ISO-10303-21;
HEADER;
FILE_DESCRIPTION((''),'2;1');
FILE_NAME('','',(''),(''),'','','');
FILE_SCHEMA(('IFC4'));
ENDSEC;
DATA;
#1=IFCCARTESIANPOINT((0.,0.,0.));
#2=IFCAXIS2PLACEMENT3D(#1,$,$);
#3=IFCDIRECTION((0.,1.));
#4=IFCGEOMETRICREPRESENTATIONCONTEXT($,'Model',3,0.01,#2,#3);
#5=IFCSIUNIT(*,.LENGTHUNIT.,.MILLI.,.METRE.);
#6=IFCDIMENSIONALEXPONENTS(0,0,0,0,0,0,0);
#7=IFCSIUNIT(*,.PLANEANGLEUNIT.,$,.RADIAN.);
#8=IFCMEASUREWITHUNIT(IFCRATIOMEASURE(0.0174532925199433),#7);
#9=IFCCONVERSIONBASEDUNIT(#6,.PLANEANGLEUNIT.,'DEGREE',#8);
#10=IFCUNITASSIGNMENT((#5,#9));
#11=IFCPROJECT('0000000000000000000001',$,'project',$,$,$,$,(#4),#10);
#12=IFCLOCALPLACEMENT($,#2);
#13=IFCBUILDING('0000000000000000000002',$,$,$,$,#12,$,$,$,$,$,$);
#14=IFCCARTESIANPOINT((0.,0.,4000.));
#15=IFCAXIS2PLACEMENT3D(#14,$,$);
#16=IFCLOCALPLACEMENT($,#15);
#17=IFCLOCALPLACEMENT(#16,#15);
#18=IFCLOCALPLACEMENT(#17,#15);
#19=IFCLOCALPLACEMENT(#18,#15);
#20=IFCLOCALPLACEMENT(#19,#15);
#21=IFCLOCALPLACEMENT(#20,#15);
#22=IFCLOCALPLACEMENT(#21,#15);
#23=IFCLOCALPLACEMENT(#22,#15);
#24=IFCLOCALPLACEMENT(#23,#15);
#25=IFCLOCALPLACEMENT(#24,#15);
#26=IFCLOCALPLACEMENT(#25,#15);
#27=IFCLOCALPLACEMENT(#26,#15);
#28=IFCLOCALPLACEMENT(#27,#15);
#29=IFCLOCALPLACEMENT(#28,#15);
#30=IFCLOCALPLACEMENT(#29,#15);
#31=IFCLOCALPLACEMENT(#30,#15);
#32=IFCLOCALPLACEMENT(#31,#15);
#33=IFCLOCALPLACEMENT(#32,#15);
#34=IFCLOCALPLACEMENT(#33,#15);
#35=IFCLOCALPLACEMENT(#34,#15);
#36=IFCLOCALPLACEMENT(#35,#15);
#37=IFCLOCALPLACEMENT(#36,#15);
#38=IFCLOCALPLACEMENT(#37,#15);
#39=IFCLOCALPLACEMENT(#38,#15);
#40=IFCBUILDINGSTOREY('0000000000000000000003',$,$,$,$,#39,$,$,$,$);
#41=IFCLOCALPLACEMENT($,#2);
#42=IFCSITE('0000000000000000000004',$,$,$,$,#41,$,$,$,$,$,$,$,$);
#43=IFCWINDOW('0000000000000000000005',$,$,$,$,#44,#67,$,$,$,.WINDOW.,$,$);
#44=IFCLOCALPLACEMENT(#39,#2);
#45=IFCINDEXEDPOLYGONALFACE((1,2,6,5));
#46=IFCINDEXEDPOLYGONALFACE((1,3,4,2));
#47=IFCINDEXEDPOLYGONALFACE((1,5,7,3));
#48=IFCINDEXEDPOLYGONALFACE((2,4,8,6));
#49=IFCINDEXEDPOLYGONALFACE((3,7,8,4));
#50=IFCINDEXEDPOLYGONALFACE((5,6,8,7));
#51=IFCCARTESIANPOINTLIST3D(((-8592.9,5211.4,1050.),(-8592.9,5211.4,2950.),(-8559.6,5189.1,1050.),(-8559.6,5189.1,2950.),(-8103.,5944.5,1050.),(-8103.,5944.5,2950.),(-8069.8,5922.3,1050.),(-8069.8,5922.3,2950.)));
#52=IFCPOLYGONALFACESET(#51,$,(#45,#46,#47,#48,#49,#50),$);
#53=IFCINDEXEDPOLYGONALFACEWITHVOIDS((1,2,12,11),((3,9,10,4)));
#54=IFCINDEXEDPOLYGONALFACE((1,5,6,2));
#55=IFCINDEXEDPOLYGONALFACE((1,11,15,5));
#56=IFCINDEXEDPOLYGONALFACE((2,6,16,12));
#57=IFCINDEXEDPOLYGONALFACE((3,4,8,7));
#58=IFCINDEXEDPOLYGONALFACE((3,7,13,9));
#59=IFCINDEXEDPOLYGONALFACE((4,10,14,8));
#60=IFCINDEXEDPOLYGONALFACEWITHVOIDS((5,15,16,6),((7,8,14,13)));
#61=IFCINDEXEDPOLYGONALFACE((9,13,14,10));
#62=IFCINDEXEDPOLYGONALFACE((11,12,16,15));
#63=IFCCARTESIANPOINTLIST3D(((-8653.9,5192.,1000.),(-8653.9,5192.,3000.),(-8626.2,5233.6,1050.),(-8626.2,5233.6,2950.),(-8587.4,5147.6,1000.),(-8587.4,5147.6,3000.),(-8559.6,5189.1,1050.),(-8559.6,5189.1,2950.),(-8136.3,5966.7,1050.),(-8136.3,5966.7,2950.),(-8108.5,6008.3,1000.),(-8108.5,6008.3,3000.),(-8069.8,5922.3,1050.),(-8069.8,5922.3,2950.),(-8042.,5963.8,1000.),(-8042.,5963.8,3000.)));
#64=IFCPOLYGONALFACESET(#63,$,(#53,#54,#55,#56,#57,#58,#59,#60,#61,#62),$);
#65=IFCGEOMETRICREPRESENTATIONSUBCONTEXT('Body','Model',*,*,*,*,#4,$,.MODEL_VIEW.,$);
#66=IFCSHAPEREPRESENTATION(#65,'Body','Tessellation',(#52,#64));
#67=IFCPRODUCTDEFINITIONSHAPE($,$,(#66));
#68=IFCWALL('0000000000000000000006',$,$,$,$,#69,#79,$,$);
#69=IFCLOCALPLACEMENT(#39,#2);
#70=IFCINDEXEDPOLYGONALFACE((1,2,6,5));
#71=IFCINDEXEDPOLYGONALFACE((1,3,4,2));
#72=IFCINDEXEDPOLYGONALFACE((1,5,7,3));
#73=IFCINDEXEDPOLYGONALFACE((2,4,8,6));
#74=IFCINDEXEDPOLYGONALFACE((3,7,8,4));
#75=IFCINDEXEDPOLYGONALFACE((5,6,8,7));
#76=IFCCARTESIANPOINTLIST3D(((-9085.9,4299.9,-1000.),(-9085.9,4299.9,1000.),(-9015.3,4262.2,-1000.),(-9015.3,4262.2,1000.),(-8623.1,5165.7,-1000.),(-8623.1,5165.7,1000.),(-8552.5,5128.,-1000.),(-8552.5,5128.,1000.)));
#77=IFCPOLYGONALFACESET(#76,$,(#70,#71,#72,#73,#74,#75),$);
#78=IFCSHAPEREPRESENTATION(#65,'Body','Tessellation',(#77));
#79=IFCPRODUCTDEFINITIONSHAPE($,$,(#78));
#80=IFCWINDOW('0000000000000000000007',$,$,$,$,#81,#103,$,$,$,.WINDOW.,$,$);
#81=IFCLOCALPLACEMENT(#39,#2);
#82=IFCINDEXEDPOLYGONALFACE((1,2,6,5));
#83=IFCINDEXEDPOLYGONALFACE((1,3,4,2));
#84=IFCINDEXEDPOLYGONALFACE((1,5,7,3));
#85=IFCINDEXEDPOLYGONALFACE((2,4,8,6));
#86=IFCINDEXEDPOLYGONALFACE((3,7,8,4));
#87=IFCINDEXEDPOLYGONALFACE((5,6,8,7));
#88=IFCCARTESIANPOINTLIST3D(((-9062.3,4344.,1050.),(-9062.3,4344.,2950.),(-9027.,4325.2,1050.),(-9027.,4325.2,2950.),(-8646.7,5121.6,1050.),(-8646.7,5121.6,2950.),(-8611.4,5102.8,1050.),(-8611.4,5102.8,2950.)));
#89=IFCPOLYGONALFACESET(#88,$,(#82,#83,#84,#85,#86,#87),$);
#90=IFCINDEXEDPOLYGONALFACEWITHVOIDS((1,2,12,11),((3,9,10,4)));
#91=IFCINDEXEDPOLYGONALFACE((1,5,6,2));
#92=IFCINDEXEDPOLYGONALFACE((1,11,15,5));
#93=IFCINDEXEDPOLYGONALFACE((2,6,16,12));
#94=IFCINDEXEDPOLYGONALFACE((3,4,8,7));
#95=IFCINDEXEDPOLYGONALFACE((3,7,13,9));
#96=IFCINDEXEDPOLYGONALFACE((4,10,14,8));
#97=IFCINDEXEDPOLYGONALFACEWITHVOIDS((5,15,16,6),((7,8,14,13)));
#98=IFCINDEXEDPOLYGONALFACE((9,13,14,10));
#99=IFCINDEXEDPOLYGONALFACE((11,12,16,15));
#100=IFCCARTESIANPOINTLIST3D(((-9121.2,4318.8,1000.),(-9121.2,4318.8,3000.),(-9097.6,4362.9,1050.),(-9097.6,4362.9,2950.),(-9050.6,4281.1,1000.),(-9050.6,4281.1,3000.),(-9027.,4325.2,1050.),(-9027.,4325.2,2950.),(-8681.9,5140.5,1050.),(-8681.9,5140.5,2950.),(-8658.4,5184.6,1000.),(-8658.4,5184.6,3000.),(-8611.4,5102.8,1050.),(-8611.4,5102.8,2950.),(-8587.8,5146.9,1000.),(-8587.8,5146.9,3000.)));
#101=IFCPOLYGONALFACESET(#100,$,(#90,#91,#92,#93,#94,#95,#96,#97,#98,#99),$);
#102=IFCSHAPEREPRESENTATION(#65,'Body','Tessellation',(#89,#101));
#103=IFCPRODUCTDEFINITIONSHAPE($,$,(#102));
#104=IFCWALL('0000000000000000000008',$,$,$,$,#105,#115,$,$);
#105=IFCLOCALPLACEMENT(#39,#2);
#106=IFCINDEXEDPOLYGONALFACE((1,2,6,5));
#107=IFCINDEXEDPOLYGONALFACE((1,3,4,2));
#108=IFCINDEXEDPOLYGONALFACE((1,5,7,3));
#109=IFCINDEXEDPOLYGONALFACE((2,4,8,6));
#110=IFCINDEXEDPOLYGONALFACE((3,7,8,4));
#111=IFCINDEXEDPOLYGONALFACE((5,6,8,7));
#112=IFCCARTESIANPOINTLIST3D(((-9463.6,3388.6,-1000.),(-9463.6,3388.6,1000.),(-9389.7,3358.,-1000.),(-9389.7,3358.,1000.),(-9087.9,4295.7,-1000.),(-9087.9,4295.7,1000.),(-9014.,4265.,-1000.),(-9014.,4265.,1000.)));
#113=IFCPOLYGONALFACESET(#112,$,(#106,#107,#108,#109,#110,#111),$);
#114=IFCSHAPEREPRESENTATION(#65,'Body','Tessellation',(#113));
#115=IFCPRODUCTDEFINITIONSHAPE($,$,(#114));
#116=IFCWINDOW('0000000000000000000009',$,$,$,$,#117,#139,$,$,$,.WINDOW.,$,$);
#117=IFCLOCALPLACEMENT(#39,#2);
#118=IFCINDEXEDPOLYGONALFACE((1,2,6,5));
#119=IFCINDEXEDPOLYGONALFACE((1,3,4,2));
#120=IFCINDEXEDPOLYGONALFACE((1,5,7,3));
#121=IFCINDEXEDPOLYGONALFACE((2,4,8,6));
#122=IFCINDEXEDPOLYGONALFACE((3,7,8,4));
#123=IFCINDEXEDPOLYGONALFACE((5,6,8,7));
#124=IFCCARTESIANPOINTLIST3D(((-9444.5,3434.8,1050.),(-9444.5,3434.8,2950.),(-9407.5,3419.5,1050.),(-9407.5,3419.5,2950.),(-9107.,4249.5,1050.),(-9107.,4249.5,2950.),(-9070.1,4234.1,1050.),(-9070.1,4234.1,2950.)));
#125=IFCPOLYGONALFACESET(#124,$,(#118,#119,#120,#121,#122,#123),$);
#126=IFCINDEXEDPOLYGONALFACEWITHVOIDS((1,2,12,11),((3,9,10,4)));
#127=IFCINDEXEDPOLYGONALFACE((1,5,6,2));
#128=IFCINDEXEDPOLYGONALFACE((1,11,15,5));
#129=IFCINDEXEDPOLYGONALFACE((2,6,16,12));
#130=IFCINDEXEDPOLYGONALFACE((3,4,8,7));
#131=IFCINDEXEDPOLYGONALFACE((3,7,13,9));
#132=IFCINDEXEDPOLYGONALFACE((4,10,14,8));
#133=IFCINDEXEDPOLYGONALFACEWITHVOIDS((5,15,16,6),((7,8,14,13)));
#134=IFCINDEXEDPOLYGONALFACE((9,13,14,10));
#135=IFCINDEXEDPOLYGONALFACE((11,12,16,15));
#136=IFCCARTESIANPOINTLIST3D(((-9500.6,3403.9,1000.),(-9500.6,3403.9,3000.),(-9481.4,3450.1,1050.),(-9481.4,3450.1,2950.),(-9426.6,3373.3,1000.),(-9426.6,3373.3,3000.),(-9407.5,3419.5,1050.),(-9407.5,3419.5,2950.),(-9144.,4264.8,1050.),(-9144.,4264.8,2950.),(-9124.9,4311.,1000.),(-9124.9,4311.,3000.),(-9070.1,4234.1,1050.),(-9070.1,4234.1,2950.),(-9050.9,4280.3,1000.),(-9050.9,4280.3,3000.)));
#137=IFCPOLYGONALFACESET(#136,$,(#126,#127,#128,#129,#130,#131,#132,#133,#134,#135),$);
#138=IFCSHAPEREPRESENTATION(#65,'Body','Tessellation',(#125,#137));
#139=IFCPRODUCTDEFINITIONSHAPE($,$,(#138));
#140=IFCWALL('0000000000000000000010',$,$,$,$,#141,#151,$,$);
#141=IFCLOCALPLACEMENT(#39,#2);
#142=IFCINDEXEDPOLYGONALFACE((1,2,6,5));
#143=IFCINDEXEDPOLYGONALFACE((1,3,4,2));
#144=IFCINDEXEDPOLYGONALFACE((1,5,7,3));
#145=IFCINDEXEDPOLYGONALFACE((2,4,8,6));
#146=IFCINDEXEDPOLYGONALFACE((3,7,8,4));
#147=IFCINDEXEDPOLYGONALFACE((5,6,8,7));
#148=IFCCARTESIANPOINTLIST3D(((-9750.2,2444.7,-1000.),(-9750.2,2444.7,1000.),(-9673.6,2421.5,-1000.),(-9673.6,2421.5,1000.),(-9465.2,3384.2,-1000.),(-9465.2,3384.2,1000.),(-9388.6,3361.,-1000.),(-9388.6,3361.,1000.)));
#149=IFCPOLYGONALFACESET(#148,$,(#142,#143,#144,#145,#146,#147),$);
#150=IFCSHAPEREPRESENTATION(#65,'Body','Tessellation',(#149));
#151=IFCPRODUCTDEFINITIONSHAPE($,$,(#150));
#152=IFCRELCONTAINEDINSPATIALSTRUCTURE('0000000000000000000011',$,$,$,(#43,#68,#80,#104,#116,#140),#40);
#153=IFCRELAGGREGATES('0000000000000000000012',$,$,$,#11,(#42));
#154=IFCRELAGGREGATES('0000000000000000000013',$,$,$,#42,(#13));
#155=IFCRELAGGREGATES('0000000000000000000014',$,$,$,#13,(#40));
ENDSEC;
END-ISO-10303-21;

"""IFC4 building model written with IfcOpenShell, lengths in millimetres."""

from ifc_helpers import new_model, entity, si_unit, converted_unit, direction, frame, origin, origin_2d, place, context, subcontext, project, spatial, rectangle, extrude, element, save


model = new_model("IFC4")

# Units and contexts
model_context = context("Model", 3, precision=0.01, world=origin(), true_north=direction((0.0, 1.0)))
body_context = subcontext(model_context, "Body", "Model", "MODEL_VIEW")
ifc_project = project(units=[si_unit("LENGTHUNIT", "METRE", prefix="MILLI"), converted_unit("PLANEANGLEUNIT", "DEGREE", entity("IfcRatioMeasure", 0.0174532925199433), si_unit("PLANEANGLEUNIT", "RADIAN"), dimensions=[0, 0, 0, 0, 0, 0, 0])], contexts=[model_context])

# Site, building, storey
site_placement = place(None, origin())
site = spatial("IfcSite", under=ifc_project, at=site_placement)
building_placement = place(None, origin())
building = spatial("IfcBuilding", under=site, at=building_placement)
placement_1 = place(None, frame((0.0, 0.0, 4000.0)))
placement_2 = place(placement_1, frame((0.0, 0.0, 4000.0)))
placement_3 = place(placement_2, frame((0.0, 0.0, 4000.0)))
placement_4 = place(placement_3, frame((0.0, 0.0, 4000.0)))
placement_5 = place(placement_4, frame((0.0, 0.0, 4000.0)))
placement_6 = place(placement_5, frame((0.0, 0.0, 4000.0)))
placement_7 = place(placement_6, frame((0.0, 0.0, 4000.0)))
placement_8 = place(placement_7, frame((0.0, 0.0, 4000.0)))
placement_9 = place(placement_8, frame((0.0, 0.0, 4000.0)))
placement_10 = place(placement_9, frame((0.0, 0.0, 4000.0)))
placement_11 = place(placement_10, frame((0.0, 0.0, 4000.0)))
placement_12 = place(placement_11, frame((0.0, 0.0, 4000.0)))
placement_13 = place(placement_12, frame((0.0, 0.0, 4000.0)))
placement_14 = place(placement_13, frame((0.0, 0.0, 4000.0)))
placement_15 = place(placement_14, frame((0.0, 0.0, 4000.0)))
placement_16 = place(placement_15, frame((0.0, 0.0, 4000.0)))
placement_17 = place(placement_16, frame((0.0, 0.0, 4000.0)))
placement_18 = place(placement_17, frame((0.0, 0.0, 4000.0)))
placement_19 = place(placement_18, frame((0.0, 0.0, 4000.0)))
placement_20 = place(placement_19, frame((0.0, 0.0, 4000.0)))
placement_21 = place(placement_20, frame((0.0, 0.0, 4000.0)))
placement_22 = place(placement_21, frame((0.0, 0.0, 4000.0)))
placement_23 = place(placement_22, frame((0.0, 0.0, 4000.0)))
storey_placement = place(placement_23, frame((0.0, 0.0, 4000.0)))
storey = spatial("IfcBuildingStorey", under=building, at=storey_placement)

# Shared definitions
cartesian_point_1 = entity("IfcCartesianPoint", [-440.9, -950.0])
shared_polyline = entity("IfcPolyline", [cartesian_point_1, entity("IfcCartesianPoint", [-440.9, 950.0]), entity("IfcCartesianPoint", [-440.9, 950.0]), entity("IfcCartesianPoint", [440.9, 950.0]), entity("IfcCartesianPoint", [440.9, 950.0]), entity("IfcCartesianPoint", [440.9, -950.0]), entity("IfcCartesianPoint", [440.9, -950.0]), entity("IfcCartesianPoint", [-440.9, -950.0]), cartesian_point_1])

# Window
window_1_placement = place(storey_placement, frame((-8314.7, 5555.7, 2000.0), z_axis=(0.0, 0.0, 1.0), x_axis=(-5555.701616, -8314.6966, 0.0)))
cartesian_point_2 = entity("IfcCartesianPoint", [-490.9, -1000.0])
element("IfcWindow", 1, at=window_1_placement, inside=storey, PredefinedType="WINDOW", context=body_context, shape_type="SweptSolid", body=[
    entity("IfcExtrudedAreaSolid", entity("IfcArbitraryClosedProfileDef", "AREA", None, shared_polyline), entity("IfcAxis2Placement3D", entity("IfcCartesianPoint", [0.0, 0.0, 0.0]), entity("IfcDirection", [0.0, -1.0, 0.0]), entity("IfcDirection", [1.0, 0.0, 0.0])), entity("IfcDirection", [0.0, 0.0, 1.0]), 40.0),
    entity("IfcExtrudedAreaSolid", entity("IfcArbitraryProfileDefWithVoids", "AREA", None, entity("IfcPolyline", [cartesian_point_2, entity("IfcCartesianPoint", [-490.9, 1000.0]), entity("IfcCartesianPoint", [-490.9, 1000.0]), entity("IfcCartesianPoint", [490.9, 1000.0]), entity("IfcCartesianPoint", [490.9, 1000.0]), entity("IfcCartesianPoint", [490.9, -1000.0]), entity("IfcCartesianPoint", [490.9, -1000.0]), entity("IfcCartesianPoint", [-490.9, -1000.0]), cartesian_point_2]), [shared_polyline]), entity("IfcAxis2Placement3D", entity("IfcCartesianPoint", [0.0, 0.0, 0.0]), entity("IfcDirection", [0.0, -1.0, 0.0]), entity("IfcDirection", [1.0, 0.0, 0.0])), entity("IfcDirection", [0.0, 0.0, 1.0]), 80.0),
])

# Wall
wall_1_placement = place(storey_placement, frame((-8819.2, 4714.0, -1000.0), z_axis=(0.0, 0.0, 1.0), x_axis=(-4713.96836, -8819.212113, 0.0)))
element("IfcWall", 2, at=wall_1_placement, inside=storey, context=body_context, shape_type="SweptSolid", body=[
    extrude(rectangle(XDim=981.7, YDim=80.0, at=origin_2d()), origin(), (0.0, 0.0, 1.0), 2000.0),
])

# Window
window_2_placement = place(storey_placement, frame((-8819.2, 4714.0, 2000.0), z_axis=(0.0, 0.0, 1.0), x_axis=(-4713.96836, -8819.212113, 0.0)))
cartesian_point_3 = entity("IfcCartesianPoint", [-490.9, -1000.0])
element("IfcWindow", 3, at=window_2_placement, inside=storey, PredefinedType="WINDOW", context=body_context, shape_type="SweptSolid", body=[
    entity("IfcExtrudedAreaSolid", entity("IfcArbitraryClosedProfileDef", "AREA", None, shared_polyline), entity("IfcAxis2Placement3D", entity("IfcCartesianPoint", [0.0, 0.0, 0.0]), entity("IfcDirection", [0.0, -1.0, 0.0]), entity("IfcDirection", [1.0, 0.0, 0.0])), entity("IfcDirection", [0.0, 0.0, 1.0]), 40.0),
    entity("IfcExtrudedAreaSolid", entity("IfcArbitraryProfileDefWithVoids", "AREA", None, entity("IfcPolyline", [cartesian_point_3, entity("IfcCartesianPoint", [-490.9, 1000.0]), entity("IfcCartesianPoint", [-490.9, 1000.0]), entity("IfcCartesianPoint", [490.9, 1000.0]), entity("IfcCartesianPoint", [490.9, 1000.0]), entity("IfcCartesianPoint", [490.9, -1000.0]), entity("IfcCartesianPoint", [490.9, -1000.0]), entity("IfcCartesianPoint", [-490.9, -1000.0]), cartesian_point_3]), [shared_polyline]), entity("IfcAxis2Placement3D", entity("IfcCartesianPoint", [0.0, 0.0, 0.0]), entity("IfcDirection", [0.0, -1.0, 0.0]), entity("IfcDirection", [1.0, 0.0, 0.0])), entity("IfcDirection", [0.0, 0.0, 1.0]), 80.0),
])

# Wall
wall_2_placement = place(storey_placement, frame((-9238.8, 3826.8, -1000.0), z_axis=(0.0, 0.0, 1.0), x_axis=(-3826.834994, -9238.795048, 0.0)))
element("IfcWall", 4, at=wall_2_placement, inside=storey, context=body_context, shape_type="SweptSolid", body=[
    extrude(rectangle(XDim=981.7, YDim=80.0, at=origin_2d()), origin(), (0.0, 0.0, 1.0), 2000.0),
])

# Window
window_3_placement = place(storey_placement, frame((-9238.8, 3826.8, 2000.0), z_axis=(0.0, 0.0, 1.0), x_axis=(-3826.834994, -9238.795048, 0.0)))
cartesian_point_4 = entity("IfcCartesianPoint", [-490.9, -1000.0])
element("IfcWindow", 5, at=window_3_placement, inside=storey, PredefinedType="WINDOW", context=body_context, shape_type="SweptSolid", body=[
    entity("IfcExtrudedAreaSolid", entity("IfcArbitraryClosedProfileDef", "AREA", None, shared_polyline), entity("IfcAxis2Placement3D", entity("IfcCartesianPoint", [0.0, 0.0, 0.0]), entity("IfcDirection", [0.0, -1.0, 0.0]), entity("IfcDirection", [1.0, 0.0, 0.0])), entity("IfcDirection", [0.0, 0.0, 1.0]), 40.0),
    entity("IfcExtrudedAreaSolid", entity("IfcArbitraryProfileDefWithVoids", "AREA", None, entity("IfcPolyline", [cartesian_point_4, entity("IfcCartesianPoint", [-490.9, 1000.0]), entity("IfcCartesianPoint", [-490.9, 1000.0]), entity("IfcCartesianPoint", [490.9, 1000.0]), entity("IfcCartesianPoint", [490.9, 1000.0]), entity("IfcCartesianPoint", [490.9, -1000.0]), entity("IfcCartesianPoint", [490.9, -1000.0]), entity("IfcCartesianPoint", [-490.9, -1000.0]), cartesian_point_4]), [shared_polyline]), entity("IfcAxis2Placement3D", entity("IfcCartesianPoint", [0.0, 0.0, 0.0]), entity("IfcDirection", [0.0, -1.0, 0.0]), entity("IfcDirection", [1.0, 0.0, 0.0])), entity("IfcDirection", [0.0, 0.0, 1.0]), 80.0),
])

# Wall
wall_3_placement = place(storey_placement, frame((-9569.4, 2902.8, -1000.0), z_axis=(0.0, 0.0, 1.0), x_axis=(-2902.847084, -9569.403263, 0.0)))
element("IfcWall", 6, at=wall_3_placement, inside=storey, context=body_context, shape_type="SweptSolid", body=[
    extrude(rectangle(XDim=981.7, YDim=80.0, at=origin_2d()), origin(), (0.0, 0.0, 1.0), 2000.0),
])

save(model, "model.ifc")
